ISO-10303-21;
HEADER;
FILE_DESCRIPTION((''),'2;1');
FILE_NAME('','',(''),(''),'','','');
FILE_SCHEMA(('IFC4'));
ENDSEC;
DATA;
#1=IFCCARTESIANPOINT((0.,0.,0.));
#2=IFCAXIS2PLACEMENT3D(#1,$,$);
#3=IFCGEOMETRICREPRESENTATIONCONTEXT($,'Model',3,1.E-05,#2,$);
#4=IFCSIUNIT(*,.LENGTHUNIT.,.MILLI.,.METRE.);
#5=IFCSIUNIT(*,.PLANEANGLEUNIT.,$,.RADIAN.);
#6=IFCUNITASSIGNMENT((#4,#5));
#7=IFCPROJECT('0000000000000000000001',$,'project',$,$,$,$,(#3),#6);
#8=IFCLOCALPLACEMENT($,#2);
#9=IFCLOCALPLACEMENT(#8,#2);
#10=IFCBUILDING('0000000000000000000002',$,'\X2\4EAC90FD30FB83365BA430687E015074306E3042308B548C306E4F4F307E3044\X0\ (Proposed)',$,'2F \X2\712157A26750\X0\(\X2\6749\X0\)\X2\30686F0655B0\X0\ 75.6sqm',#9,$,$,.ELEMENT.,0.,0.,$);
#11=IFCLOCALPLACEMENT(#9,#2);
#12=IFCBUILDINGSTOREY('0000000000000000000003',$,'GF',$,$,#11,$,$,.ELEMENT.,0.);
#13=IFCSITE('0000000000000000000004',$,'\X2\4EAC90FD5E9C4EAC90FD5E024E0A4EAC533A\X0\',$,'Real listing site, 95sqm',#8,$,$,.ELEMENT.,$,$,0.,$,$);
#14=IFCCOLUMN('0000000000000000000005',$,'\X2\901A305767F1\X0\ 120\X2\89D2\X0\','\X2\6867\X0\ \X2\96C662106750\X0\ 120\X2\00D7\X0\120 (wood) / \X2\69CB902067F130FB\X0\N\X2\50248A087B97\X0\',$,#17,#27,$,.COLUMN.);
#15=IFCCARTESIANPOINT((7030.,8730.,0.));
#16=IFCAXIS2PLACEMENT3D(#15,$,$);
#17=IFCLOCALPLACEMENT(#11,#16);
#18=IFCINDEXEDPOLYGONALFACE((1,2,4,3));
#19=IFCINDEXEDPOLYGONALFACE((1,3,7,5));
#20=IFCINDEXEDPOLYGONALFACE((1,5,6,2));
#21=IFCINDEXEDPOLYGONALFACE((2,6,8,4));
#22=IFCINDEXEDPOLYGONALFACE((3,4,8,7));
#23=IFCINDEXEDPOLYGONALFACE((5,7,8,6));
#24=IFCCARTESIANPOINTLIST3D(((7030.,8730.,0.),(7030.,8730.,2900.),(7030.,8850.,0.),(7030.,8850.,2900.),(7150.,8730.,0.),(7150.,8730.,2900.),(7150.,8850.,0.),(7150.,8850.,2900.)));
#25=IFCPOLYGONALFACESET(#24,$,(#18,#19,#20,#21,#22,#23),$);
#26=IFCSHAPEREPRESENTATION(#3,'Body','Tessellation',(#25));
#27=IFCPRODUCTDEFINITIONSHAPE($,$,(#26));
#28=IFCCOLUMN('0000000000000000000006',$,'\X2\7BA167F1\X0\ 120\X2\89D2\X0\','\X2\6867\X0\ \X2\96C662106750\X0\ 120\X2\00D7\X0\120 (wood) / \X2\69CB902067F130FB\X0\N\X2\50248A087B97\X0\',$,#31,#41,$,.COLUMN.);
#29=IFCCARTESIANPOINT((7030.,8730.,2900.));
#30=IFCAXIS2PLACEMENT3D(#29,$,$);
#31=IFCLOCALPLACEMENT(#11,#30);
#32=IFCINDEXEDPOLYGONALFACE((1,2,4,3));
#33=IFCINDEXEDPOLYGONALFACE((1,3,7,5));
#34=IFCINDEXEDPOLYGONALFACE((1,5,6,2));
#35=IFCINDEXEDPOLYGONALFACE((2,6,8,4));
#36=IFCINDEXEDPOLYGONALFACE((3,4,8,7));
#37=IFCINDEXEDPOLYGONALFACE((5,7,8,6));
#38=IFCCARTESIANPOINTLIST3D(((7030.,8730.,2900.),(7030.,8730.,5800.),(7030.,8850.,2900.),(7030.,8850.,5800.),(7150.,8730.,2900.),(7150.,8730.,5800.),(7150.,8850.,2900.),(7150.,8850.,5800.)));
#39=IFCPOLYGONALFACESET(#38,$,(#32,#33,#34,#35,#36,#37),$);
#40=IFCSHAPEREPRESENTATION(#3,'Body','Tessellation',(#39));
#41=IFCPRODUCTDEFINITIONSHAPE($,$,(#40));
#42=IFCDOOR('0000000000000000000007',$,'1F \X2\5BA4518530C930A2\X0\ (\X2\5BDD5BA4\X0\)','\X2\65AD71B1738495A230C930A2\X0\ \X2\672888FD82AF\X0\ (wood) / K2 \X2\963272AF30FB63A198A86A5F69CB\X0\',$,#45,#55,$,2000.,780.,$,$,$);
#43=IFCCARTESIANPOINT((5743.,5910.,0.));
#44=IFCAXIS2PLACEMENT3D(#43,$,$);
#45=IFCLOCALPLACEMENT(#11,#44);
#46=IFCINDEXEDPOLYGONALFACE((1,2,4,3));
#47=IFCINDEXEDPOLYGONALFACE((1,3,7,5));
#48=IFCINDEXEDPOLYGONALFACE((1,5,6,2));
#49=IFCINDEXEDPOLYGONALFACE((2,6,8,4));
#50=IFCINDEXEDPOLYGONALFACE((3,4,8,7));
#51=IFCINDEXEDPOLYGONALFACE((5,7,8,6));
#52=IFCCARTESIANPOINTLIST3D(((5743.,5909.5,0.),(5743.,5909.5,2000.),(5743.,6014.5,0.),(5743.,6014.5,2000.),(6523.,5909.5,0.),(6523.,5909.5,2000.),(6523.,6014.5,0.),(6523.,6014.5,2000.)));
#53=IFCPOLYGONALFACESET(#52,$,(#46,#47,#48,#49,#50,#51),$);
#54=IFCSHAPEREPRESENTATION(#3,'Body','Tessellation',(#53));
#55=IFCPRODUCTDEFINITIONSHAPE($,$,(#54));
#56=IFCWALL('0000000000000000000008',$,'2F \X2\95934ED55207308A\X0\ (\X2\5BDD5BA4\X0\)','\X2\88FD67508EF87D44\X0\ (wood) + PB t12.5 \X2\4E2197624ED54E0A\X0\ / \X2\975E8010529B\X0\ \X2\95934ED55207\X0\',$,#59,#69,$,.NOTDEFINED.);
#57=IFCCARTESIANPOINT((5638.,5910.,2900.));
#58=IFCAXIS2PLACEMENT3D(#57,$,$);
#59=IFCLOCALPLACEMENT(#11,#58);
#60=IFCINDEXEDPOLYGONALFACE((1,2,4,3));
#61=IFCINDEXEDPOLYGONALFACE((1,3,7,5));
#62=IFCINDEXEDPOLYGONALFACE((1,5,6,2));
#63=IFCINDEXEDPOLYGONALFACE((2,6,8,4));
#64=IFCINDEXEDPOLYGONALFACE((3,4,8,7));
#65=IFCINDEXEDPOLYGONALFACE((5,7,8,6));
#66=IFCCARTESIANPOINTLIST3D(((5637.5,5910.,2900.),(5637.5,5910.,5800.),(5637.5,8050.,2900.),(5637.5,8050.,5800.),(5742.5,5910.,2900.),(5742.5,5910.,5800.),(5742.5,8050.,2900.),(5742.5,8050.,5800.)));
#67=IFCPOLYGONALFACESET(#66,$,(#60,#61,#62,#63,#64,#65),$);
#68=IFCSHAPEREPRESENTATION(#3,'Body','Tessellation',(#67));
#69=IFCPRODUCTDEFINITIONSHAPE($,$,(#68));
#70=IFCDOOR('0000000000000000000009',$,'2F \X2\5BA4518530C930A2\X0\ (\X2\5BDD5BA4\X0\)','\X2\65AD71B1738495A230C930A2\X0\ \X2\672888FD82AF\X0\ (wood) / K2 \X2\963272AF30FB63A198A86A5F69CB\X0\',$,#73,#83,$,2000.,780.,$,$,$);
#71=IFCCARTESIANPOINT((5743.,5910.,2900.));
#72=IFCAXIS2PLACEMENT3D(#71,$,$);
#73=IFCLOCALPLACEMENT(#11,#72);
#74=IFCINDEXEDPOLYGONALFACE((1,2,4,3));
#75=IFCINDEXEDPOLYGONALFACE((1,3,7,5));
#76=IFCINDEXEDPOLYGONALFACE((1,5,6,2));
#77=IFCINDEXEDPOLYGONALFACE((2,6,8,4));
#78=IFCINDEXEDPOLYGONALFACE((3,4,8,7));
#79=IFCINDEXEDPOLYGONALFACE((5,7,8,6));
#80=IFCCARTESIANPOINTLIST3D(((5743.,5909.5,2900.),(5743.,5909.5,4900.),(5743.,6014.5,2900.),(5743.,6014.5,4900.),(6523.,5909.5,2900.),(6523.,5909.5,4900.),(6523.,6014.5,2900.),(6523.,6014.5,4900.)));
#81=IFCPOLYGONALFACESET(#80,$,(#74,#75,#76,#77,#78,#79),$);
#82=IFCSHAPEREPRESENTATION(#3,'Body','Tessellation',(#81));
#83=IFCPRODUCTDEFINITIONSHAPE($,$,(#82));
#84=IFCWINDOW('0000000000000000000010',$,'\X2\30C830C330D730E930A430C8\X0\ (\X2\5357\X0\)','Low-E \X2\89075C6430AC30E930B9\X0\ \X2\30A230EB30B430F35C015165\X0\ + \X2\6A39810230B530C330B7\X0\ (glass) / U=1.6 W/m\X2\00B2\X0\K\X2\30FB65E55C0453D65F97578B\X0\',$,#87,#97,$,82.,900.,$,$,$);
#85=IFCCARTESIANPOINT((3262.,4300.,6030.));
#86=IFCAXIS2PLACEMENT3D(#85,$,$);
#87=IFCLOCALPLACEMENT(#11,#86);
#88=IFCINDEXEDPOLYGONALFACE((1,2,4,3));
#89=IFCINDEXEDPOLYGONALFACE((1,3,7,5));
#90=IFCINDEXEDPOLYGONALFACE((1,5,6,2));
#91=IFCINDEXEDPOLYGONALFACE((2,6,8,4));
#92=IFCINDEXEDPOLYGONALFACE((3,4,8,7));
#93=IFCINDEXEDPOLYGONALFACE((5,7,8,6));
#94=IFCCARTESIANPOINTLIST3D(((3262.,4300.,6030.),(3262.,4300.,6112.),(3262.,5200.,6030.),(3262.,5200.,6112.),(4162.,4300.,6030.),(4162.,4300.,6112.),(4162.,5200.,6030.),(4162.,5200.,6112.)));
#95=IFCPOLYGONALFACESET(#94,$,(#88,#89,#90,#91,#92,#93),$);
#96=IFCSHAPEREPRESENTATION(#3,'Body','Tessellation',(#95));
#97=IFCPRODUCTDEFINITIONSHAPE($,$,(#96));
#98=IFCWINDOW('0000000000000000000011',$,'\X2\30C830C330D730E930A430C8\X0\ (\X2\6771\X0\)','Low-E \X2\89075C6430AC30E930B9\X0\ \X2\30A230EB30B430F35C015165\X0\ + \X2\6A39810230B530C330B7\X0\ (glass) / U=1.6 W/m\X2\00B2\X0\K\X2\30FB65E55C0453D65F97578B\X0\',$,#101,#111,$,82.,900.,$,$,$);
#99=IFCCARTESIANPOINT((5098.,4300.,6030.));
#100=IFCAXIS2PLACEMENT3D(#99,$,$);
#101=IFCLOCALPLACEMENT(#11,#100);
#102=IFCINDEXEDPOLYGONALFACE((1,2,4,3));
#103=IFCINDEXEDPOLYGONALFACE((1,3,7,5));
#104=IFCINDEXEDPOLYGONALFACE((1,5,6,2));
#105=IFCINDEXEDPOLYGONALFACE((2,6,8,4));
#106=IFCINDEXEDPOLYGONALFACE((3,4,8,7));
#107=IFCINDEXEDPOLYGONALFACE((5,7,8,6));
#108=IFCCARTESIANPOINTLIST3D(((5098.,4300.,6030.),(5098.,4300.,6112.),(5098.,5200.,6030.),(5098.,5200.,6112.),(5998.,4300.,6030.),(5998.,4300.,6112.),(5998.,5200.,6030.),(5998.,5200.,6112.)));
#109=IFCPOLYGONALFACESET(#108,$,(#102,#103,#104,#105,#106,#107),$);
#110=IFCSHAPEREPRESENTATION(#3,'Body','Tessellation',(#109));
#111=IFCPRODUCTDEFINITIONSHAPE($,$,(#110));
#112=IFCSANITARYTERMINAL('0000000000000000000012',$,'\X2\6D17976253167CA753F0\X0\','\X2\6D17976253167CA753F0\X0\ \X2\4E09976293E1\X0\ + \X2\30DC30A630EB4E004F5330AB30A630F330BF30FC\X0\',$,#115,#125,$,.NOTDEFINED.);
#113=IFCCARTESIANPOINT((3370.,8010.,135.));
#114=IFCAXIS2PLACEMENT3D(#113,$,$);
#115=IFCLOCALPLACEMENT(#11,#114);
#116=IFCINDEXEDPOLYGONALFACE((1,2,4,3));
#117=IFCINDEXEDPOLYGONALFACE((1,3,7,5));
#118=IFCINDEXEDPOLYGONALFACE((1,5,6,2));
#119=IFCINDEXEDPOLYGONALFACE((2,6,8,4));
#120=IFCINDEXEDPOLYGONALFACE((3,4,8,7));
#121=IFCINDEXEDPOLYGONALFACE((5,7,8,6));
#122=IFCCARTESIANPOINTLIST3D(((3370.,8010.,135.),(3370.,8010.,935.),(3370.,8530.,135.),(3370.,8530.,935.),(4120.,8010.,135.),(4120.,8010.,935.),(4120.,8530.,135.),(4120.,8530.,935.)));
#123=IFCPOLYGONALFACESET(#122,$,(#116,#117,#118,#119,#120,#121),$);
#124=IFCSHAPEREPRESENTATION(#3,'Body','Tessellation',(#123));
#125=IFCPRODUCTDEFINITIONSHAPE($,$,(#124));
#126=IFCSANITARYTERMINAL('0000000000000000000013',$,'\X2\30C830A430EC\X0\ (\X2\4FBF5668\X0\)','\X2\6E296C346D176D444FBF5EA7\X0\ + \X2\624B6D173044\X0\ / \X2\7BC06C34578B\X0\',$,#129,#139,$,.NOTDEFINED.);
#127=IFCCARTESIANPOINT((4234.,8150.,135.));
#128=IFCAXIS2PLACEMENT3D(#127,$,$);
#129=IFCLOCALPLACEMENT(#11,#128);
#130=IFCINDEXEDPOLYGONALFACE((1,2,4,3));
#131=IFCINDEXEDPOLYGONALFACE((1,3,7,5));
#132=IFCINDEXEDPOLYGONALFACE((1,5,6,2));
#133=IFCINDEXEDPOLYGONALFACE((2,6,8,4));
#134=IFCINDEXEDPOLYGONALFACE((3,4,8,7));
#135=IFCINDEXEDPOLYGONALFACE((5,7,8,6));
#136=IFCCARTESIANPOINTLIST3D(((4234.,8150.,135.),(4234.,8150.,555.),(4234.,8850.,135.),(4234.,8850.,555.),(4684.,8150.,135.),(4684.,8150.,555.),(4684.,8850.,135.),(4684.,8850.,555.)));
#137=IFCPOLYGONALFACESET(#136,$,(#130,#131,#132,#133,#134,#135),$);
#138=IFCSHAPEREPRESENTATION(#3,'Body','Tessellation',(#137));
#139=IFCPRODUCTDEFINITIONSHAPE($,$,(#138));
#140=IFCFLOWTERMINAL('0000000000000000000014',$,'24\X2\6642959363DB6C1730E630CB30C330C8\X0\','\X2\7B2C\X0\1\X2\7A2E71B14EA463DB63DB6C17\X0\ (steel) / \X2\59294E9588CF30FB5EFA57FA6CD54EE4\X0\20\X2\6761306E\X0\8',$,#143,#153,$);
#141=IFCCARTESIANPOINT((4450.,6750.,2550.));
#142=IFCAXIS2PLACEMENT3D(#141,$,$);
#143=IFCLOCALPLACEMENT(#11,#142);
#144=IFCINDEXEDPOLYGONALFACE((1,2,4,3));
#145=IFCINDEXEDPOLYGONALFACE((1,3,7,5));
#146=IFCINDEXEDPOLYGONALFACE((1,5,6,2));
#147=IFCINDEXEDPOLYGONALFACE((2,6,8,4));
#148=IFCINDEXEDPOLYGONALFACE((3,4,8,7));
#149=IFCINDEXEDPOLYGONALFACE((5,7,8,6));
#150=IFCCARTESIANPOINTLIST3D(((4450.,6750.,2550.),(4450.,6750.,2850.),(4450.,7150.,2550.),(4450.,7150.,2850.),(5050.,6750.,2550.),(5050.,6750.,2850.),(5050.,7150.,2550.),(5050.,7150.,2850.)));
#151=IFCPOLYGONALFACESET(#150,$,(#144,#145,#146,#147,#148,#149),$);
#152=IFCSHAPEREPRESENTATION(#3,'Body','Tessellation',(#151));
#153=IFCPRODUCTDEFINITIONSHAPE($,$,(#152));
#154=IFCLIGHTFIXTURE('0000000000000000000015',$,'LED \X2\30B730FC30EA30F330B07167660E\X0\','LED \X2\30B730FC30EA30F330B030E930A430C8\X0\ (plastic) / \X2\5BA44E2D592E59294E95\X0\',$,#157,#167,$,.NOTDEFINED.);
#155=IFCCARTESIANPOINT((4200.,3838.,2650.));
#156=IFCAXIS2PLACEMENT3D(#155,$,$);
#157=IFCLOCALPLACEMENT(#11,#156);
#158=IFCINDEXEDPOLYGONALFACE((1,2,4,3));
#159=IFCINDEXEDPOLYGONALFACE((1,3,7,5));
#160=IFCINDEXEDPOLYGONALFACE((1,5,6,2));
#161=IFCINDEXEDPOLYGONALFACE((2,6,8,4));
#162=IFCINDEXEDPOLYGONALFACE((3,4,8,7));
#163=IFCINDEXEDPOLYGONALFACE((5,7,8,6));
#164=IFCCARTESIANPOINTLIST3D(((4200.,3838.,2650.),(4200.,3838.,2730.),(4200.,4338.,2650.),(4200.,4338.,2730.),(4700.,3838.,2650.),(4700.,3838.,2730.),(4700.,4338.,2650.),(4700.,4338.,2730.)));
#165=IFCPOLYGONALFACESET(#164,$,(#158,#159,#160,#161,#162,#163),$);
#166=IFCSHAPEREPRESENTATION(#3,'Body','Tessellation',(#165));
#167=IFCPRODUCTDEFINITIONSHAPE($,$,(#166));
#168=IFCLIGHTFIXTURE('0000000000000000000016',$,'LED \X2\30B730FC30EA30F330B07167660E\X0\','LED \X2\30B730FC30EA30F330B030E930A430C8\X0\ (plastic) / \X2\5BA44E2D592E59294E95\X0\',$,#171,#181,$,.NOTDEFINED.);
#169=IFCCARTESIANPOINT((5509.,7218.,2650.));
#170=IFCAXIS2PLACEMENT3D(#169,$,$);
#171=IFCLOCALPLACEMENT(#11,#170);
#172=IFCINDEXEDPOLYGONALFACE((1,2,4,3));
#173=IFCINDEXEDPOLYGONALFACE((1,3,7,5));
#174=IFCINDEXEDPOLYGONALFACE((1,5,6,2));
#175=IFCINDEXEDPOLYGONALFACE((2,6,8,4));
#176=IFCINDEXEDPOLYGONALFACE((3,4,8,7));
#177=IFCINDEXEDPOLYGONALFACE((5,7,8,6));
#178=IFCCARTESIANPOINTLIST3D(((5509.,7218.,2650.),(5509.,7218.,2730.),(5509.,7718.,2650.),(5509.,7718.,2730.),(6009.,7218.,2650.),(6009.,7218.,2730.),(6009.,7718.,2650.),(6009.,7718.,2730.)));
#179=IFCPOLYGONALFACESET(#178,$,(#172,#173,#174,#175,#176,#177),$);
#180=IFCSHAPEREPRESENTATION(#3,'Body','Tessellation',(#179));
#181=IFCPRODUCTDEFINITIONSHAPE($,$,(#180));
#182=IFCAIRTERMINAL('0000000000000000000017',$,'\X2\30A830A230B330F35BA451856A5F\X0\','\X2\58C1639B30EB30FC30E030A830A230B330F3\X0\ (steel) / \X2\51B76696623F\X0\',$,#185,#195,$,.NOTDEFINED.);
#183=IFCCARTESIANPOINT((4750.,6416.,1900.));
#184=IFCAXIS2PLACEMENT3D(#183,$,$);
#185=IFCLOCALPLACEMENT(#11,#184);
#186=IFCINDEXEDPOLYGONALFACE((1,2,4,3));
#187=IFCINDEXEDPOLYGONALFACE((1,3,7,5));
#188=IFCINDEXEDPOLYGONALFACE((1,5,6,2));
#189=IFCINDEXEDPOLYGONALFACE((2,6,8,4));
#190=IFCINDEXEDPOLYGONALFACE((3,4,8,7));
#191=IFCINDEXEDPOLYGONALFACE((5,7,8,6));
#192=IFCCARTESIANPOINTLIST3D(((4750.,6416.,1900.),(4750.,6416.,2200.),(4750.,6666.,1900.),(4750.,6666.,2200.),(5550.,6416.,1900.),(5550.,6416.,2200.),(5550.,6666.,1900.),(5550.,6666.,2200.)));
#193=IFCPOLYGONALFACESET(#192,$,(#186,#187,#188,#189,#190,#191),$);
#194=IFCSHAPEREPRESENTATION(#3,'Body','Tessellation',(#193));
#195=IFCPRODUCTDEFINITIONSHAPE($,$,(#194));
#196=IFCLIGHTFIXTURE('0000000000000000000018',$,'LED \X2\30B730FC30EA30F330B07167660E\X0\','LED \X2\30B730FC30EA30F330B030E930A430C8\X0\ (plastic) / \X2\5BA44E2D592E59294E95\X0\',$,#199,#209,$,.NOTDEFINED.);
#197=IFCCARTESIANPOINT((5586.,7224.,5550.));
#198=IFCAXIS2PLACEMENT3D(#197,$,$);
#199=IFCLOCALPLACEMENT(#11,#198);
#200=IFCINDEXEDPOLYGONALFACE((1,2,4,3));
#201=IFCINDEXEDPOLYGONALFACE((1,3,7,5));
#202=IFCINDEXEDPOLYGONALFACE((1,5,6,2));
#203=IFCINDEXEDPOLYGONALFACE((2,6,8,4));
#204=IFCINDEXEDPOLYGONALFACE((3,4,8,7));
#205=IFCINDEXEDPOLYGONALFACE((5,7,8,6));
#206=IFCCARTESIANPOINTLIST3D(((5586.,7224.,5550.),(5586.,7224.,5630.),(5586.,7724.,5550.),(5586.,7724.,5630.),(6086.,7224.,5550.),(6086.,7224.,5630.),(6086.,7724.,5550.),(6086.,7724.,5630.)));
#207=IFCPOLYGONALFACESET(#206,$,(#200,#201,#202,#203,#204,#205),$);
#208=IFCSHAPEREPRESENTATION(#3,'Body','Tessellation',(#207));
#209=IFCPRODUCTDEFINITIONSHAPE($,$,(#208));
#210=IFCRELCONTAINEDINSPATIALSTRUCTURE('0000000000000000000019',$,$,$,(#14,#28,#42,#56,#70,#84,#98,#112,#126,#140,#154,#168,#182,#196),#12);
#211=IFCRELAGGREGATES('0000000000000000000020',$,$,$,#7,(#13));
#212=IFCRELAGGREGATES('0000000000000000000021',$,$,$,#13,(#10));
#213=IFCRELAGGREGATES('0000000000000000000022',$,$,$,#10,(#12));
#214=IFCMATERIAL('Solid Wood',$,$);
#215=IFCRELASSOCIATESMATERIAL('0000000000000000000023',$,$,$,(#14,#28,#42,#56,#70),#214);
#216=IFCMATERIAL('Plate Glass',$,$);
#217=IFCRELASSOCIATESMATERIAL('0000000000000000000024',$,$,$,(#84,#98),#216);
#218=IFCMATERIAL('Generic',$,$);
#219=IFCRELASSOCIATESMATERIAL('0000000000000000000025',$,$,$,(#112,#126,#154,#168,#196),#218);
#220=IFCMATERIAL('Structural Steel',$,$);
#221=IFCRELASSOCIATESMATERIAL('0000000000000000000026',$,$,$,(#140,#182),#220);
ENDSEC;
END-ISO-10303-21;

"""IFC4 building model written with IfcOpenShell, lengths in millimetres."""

from ifc_helpers import new_model, si_unit, frame, frame_2d, origin, place, context, project, spatial, rectangle, extrude, material, element, save


model = new_model("IFC4")

# Units and contexts
model_context = context("Model", 3, precision=1e-05, world=origin())
ifc_project = project(units=[si_unit("LENGTHUNIT", "METRE", prefix="MILLI"), si_unit("PLANEANGLEUNIT", "RADIAN")], contexts=[model_context])

# Site, building, storey
site_placement = place(None, origin())
site = spatial("IfcSite", under=ifc_project, at=site_placement, Name="京都府京都市上京区", ObjectType="Real listing site, 95sqm", CompositionType="ELEMENT", RefElevation=0.0)
building_placement = place(site_placement, origin())
building = spatial("IfcBuilding", under=site, at=building_placement, Name="京都・茶室と縁側のある和の住まい (Proposed)", ObjectType="2F 無垢材(杉)と漆喰 75.6sqm", CompositionType="ELEMENT", ElevationOfRefHeight=0.0, ElevationOfTerrain=0.0)
storey_placement = place(building_placement, origin())
storey = spatial("IfcBuildingStorey", under=building, at=storey_placement, Name="GF", CompositionType="ELEMENT", Elevation=0.0)

# Columns
ifc_material_1 = material(Name="Solid Wood")
column_1_placement = place(storey_placement, frame((7030.0, 8730.0, 0.0)))
element("IfcColumn", 1, at=column_1_placement, inside=storey, material=ifc_material_1, Name="通し柱 120角", Description="桧 集成材 120×120 (wood) / 構造柱・N値計算", PredefinedType="COLUMN", context=model_context, shape_type="SweptSolid", body=[
    extrude(rectangle(XDim=120.0, YDim=120.0, at=frame_2d((60.0, 60.0))), frame((7030.0, 8730.0, 0.0)), (0.0, 0.0, 1.0), 2900.0),
])
column_2_placement = place(storey_placement, frame((7030.0, 8730.0, 2900.0)))
element("IfcColumn", 2, at=column_2_placement, inside=storey, material=ifc_material_1, Name="管柱 120角", Description="桧 集成材 120×120 (wood) / 構造柱・N値計算", PredefinedType="COLUMN", context=model_context, shape_type="SweptSolid", body=[
    extrude(rectangle(XDim=120.0, YDim=120.0, at=frame_2d((60.0, 60.0))), frame((7030.0, 8730.0, 2900.0)), (0.0, 0.0, 1.0), 2900.0),
])

# Door
door_1_placement = place(storey_placement, frame((5743.0, 5910.0, 0.0)))
element("IfcDoor", 3, at=door_1_placement, inside=storey, material=ifc_material_1, Name="1F 室内ドア (寝室)", Description="断熱玄関ドア 木製芯 (wood) / K2 防犯・採風機構", OverallHeight=2000.0, OverallWidth=780.0, context=model_context, shape_type="SweptSolid", body=[
    extrude(rectangle(XDim=780.0, YDim=105.0, at=frame_2d((390.0, 52.0))), frame((5743.0, 5910.0, 0.0)), (0.0, 0.0, 1.0), 2000.0),
])

# Wall
wall_1_placement = place(storey_placement, frame((5638.0, 5910.0, 2900.0)))
element("IfcWall", 4, at=wall_1_placement, inside=storey, material=ifc_material_1, Name="2F 間仕切り (寝室)", Description="製材軸組 (wood) + PB t12.5 両面仕上 / 非耐力 間仕切", PredefinedType="NOTDEFINED", context=model_context, shape_type="SweptSolid", body=[
    extrude(rectangle(XDim=105.0, YDim=2140.0, at=frame_2d((52.0, 1070.0))), frame((5638.0, 5910.0, 2900.0)), (0.0, 0.0, 1.0), 2900.0),
])

# Door
door_2_placement = place(storey_placement, frame((5743.0, 5910.0, 2900.0)))
element("IfcDoor", 5, at=door_2_placement, inside=storey, material=ifc_material_1, Name="2F 室内ドア (寝室)", Description="断熱玄関ドア 木製芯 (wood) / K2 防犯・採風機構", OverallHeight=2000.0, OverallWidth=780.0, context=model_context, shape_type="SweptSolid", body=[
    extrude(rectangle(XDim=780.0, YDim=105.0, at=frame_2d((390.0, 52.0))), frame((5743.0, 5910.0, 2900.0)), (0.0, 0.0, 1.0), 2000.0),
])

# Windows
ifc_material_2 = material(Name="Plate Glass")
window_1_placement = place(storey_placement, frame((3262.0, 4300.0, 6030.0)))
element("IfcWindow", 6, at=window_1_placement, inside=storey, material=ifc_material_2, Name="トップライト (南)", Description="Low-E 複層ガラス アルゴン封入 + 樹脂サッシ (glass) / U=1.6 W/m²K・日射取得型", OverallHeight=82.0, OverallWidth=900.0, context=model_context, shape_type="SweptSolid", body=[
    extrude(rectangle(XDim=900.0, YDim=900.0, at=frame_2d((450.0, 450.0))), frame((3262.0, 4300.0, 6030.0)), (0.0, 0.0, 1.0), 82.0),
])
window_2_placement = place(storey_placement, frame((5098.0, 4300.0, 6030.0)))
element("IfcWindow", 7, at=window_2_placement, inside=storey, material=ifc_material_2, Name="トップライト (東)", Description="Low-E 複層ガラス アルゴン封入 + 樹脂サッシ (glass) / U=1.6 W/m²K・日射取得型", OverallHeight=82.0, OverallWidth=900.0, context=model_context, shape_type="SweptSolid", body=[
    extrude(rectangle(XDim=900.0, YDim=900.0, at=frame_2d((450.0, 450.0))), frame((5098.0, 4300.0, 6030.0)), (0.0, 0.0, 1.0), 82.0),
])

# Sanitary terminals
ifc_material_3 = material(Name="Generic")
sanitary_terminal_1_placement = place(storey_placement, frame((3370.0, 8010.0, 135.0)))
element("IfcSanitaryTerminal", 8, at=sanitary_terminal_1_placement, inside=storey, material=ifc_material_3, Name="洗面化粧台", Description="洗面化粧台 三面鏡 + ボウル一体カウンター", PredefinedType="NOTDEFINED", context=model_context, shape_type="SweptSolid", body=[
    extrude(rectangle(XDim=750.0, YDim=520.0, at=frame_2d((375.0, 260.0))), frame((3370.0, 8010.0, 135.0)), (0.0, 0.0, 1.0), 800.0),
])
sanitary_terminal_2_placement = place(storey_placement, frame((4234.0, 8150.0, 135.0)))
element("IfcSanitaryTerminal", 9, at=sanitary_terminal_2_placement, inside=storey, material=ifc_material_3, Name="トイレ (便器)", Description="温水洗浄便座 + 手洗い / 節水型", PredefinedType="NOTDEFINED", context=model_context, shape_type="SweptSolid", body=[
    extrude(rectangle(XDim=450.0, YDim=700.0, at=frame_2d((225.0, 350.0))), frame((4234.0, 8150.0, 135.0)), (0.0, 0.0, 1.0), 420.0),
])

# Flow terminal
ifc_material_4 = material(Name="Structural Steel")
flow_terminal_placement = place(storey_placement, frame((4450.0, 6750.0, 2550.0)))
element("IfcFlowTerminal", 10, at=flow_terminal_placement, inside=storey, material=ifc_material_4, Name="24時間換気ユニット", Description="第1種熱交換換気 (steel) / 天井裏・建基法令20条の8", context=model_context, shape_type="SweptSolid", body=[
    extrude(rectangle(XDim=600.0, YDim=400.0, at=frame_2d((300.0, 200.0))), frame((4450.0, 6750.0, 2550.0)), (0.0, 0.0, 1.0), 300.0),
])

# Light fixtures
light_fixture_1_placement = place(storey_placement, frame((4200.0, 3838.0, 2650.0)))
element("IfcLightFixture", 11, at=light_fixture_1_placement, inside=storey, material=ifc_material_3, Name="LED シーリング照明", Description="LED シーリングライト (plastic) / 室中央天井", PredefinedType="NOTDEFINED", context=model_context, shape_type="SweptSolid", body=[
    extrude(rectangle(XDim=500.0, YDim=500.0, at=frame_2d((250.0, 250.0))), frame((4200.0, 3838.0, 2650.0)), (0.0, 0.0, 1.0), 80.0),
])
light_fixture_2_placement = place(storey_placement, frame((5509.0, 7218.0, 2650.0)))
element("IfcLightFixture", 12, at=light_fixture_2_placement, inside=storey, material=ifc_material_3, Name="LED シーリング照明", Description="LED シーリングライト (plastic) / 室中央天井", PredefinedType="NOTDEFINED", context=model_context, shape_type="SweptSolid", body=[
    extrude(rectangle(XDim=500.0, YDim=500.0, at=frame_2d((250.0, 250.0))), frame((5509.0, 7218.0, 2650.0)), (0.0, 0.0, 1.0), 80.0),
])

# Air terminal
air_terminal_placement = place(storey_placement, frame((4750.0, 6416.0, 1900.0)))
element("IfcAirTerminal", 13, at=air_terminal_placement, inside=storey, material=ifc_material_4, Name="エアコン室内機", Description="壁掛ルームエアコン (steel) / 冷暖房", PredefinedType="NOTDEFINED", context=model_context, shape_type="SweptSolid", body=[
    extrude(rectangle(XDim=800.0, YDim=250.0, at=frame_2d((400.0, 125.0))), frame((4750.0, 6416.0, 1900.0)), (0.0, 0.0, 1.0), 300.0),
])

# Light fixture
light_fixture_3_placement = place(storey_placement, frame((5586.0, 7224.0, 5550.0)))
element("IfcLightFixture", 14, at=light_fixture_3_placement, inside=storey, material=ifc_material_3, Name="LED シーリング照明", Description="LED シーリングライト (plastic) / 室中央天井", PredefinedType="NOTDEFINED", context=model_context, shape_type="SweptSolid", body=[
    extrude(rectangle(XDim=500.0, YDim=500.0, at=frame_2d((250.0, 250.0))), frame((5586.0, 7224.0, 5550.0)), (0.0, 0.0, 1.0), 80.0),
])

save(model, "model.ifc")
